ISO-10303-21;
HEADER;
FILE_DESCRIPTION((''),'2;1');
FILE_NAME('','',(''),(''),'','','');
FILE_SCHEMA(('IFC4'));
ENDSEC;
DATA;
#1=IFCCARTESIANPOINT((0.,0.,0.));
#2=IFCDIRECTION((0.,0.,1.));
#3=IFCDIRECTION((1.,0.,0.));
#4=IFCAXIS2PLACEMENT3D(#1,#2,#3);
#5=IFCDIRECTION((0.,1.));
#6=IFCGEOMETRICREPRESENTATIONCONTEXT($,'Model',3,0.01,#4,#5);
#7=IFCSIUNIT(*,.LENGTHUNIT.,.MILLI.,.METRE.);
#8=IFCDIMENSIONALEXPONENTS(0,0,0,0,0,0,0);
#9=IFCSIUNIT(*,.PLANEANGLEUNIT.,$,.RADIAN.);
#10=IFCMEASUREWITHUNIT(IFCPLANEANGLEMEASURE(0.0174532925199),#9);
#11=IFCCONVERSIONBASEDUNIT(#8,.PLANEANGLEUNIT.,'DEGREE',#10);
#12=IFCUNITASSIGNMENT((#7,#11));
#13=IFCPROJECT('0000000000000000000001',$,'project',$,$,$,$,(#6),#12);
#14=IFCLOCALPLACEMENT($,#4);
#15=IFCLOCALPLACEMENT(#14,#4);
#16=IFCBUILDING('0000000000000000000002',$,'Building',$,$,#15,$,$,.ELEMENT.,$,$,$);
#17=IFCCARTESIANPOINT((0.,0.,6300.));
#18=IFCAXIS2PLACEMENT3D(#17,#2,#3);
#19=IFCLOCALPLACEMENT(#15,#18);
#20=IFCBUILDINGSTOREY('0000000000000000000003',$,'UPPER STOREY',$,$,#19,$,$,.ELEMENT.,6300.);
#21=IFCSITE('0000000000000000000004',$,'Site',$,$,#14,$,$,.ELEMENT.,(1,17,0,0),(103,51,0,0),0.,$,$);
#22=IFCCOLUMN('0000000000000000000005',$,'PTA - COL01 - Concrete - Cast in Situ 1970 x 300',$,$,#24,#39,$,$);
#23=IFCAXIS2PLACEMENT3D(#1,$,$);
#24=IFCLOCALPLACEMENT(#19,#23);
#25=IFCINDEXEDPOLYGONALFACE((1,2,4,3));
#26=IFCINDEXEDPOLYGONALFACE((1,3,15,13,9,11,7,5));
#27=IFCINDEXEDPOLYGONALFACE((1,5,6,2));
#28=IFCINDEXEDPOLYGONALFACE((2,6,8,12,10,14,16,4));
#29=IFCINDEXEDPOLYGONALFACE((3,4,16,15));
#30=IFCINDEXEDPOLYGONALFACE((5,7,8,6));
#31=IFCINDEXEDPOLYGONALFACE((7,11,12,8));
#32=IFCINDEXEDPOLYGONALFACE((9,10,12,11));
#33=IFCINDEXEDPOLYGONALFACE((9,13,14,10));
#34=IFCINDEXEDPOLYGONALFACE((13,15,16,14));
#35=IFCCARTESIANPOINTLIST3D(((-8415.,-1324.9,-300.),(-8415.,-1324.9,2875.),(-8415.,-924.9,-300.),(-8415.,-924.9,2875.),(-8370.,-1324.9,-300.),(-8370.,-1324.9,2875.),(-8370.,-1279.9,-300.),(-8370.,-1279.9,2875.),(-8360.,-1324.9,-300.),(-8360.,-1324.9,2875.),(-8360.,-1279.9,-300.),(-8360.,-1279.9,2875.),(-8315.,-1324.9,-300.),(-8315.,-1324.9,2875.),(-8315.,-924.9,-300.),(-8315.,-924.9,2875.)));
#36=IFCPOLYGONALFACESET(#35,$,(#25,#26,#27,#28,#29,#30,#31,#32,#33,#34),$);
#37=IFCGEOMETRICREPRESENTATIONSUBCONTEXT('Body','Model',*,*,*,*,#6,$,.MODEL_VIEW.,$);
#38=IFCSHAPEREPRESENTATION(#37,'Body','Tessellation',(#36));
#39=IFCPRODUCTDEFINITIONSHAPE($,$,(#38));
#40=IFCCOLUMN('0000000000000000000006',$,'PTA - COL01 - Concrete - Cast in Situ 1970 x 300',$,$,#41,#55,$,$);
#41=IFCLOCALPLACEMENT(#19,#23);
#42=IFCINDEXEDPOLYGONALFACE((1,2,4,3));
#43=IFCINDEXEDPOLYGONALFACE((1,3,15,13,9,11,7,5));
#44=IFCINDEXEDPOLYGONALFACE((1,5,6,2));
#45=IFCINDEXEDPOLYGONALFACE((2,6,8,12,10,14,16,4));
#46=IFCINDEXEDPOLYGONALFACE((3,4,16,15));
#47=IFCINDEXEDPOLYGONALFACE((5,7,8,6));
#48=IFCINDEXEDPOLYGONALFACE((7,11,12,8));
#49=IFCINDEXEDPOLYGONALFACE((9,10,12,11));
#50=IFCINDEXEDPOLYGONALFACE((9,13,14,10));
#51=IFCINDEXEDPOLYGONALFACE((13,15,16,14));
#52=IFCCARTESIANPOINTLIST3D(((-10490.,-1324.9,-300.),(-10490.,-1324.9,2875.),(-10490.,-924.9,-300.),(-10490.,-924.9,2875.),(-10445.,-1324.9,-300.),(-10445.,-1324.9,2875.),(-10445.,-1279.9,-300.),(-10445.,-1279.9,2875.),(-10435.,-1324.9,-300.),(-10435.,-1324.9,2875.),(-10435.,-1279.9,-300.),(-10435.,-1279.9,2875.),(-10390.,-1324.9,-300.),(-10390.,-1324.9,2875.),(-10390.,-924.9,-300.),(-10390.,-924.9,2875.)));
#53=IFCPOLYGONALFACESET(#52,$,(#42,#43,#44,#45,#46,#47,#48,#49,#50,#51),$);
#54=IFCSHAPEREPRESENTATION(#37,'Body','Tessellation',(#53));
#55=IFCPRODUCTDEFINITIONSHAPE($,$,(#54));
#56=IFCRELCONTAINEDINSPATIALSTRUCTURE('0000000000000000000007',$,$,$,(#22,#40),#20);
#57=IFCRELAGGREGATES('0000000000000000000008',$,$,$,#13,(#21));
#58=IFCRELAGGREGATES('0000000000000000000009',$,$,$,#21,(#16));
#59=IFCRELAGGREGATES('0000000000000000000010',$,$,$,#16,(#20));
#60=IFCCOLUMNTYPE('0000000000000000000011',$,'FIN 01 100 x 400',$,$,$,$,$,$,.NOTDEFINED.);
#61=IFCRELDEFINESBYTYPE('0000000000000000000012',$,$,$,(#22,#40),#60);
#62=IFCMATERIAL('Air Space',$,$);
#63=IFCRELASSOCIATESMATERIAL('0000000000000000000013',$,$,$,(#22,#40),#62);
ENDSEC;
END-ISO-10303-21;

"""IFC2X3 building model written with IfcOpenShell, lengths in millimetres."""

from ifc_helpers import new_model, entity, si_unit, converted_unit, direction, frame, origin_with_axes, place, context, subcontext, project, spatial, polyline, outline, extrude, material, type_object, element, save


model = new_model("IFC2X3")

# Units and contexts
model_context = context("Model", 3, precision=0.01, world=origin_with_axes(), true_north=direction((0.0, 1.0)))
body_context = subcontext(model_context, "Body", "Model", "MODEL_VIEW")
ifc_project = project(units=[si_unit("LENGTHUNIT", "METRE", prefix="MILLI"), converted_unit("PLANEANGLEUNIT", "DEGREE", entity("IfcPlaneAngleMeasure", 0.0174532925199), si_unit("PLANEANGLEUNIT", "RADIAN"), dimensions=[0, 0, 0, 0, 0, 0, 0])], contexts=[model_context])

# Site, building, storey
site_placement = place(None, origin_with_axes())
site = spatial("IfcSite", under=ifc_project, at=site_placement, Name="Site", CompositionType="ELEMENT", RefLatitude=(1, 17, 0, 0), RefLongitude=(103, 51, 0, 0), RefElevation=0.0)
building_placement = place(site_placement, origin_with_axes())
building = spatial("IfcBuilding", under=site, at=building_placement, Name="Building", CompositionType="ELEMENT")
storey_placement = place(building_placement, frame((0.0, 0.0, 6300.0), z_axis=(0.0, 0.0, 1.0), x_axis=(1.0, 0.0, 0.0)))
storey = spatial("IfcBuildingStorey", under=building, at=storey_placement, Name="UPPER STOREY", CompositionType="ELEMENT", Elevation=6300.0)

# Columns
ifc_material_1 = material(Name="Air Space")
column_type = type_object("IfcColumnType", Name="FIN 01 100 x 400", PredefinedType="NOTDEFINED")
for number, where, z_axis, x_axis, name in (
    (1, (-8364.9, -1324.9, -300.0), (0.0, 0.0, 1.0), (-1.0, 0.0, 0.0), "PTA - COL01 - Concrete - Cast in Situ 1970 x 300"),
    (2, (-10439.9, -1324.9, -300.0), (0.0, 0.0, 1.0), (-1.0, 0.0, 0.0), "PTA - COL01 - Concrete - Cast in Situ 1970 x 300"),
):
    element("IfcColumn", number, at=place(storey_placement, frame(where, z_axis=z_axis, x_axis=x_axis)), inside=storey, type_object=column_type, material=ifc_material_1, Name=name, context=body_context, shape_type="SweptSolid", body=[
        extrude(outline(polyline([(-50.0, 0.0), (-50.0, -400.0), (50.0, -400.0), (50.0, 0.0), (5.0, 0.0), (5.0, -45.0), (-5.0, -45.0), (-5.0, 0.0), (-50.0, 0.0)])), frame((0.0, 0.0, 0.0), z_axis=(0.0, 0.0, -1.0), x_axis=(-1.0, 0.0, 0.0)), (0.0, 0.0, -1.0), 3175.0),
    ])

save(model, "model.ifc")
